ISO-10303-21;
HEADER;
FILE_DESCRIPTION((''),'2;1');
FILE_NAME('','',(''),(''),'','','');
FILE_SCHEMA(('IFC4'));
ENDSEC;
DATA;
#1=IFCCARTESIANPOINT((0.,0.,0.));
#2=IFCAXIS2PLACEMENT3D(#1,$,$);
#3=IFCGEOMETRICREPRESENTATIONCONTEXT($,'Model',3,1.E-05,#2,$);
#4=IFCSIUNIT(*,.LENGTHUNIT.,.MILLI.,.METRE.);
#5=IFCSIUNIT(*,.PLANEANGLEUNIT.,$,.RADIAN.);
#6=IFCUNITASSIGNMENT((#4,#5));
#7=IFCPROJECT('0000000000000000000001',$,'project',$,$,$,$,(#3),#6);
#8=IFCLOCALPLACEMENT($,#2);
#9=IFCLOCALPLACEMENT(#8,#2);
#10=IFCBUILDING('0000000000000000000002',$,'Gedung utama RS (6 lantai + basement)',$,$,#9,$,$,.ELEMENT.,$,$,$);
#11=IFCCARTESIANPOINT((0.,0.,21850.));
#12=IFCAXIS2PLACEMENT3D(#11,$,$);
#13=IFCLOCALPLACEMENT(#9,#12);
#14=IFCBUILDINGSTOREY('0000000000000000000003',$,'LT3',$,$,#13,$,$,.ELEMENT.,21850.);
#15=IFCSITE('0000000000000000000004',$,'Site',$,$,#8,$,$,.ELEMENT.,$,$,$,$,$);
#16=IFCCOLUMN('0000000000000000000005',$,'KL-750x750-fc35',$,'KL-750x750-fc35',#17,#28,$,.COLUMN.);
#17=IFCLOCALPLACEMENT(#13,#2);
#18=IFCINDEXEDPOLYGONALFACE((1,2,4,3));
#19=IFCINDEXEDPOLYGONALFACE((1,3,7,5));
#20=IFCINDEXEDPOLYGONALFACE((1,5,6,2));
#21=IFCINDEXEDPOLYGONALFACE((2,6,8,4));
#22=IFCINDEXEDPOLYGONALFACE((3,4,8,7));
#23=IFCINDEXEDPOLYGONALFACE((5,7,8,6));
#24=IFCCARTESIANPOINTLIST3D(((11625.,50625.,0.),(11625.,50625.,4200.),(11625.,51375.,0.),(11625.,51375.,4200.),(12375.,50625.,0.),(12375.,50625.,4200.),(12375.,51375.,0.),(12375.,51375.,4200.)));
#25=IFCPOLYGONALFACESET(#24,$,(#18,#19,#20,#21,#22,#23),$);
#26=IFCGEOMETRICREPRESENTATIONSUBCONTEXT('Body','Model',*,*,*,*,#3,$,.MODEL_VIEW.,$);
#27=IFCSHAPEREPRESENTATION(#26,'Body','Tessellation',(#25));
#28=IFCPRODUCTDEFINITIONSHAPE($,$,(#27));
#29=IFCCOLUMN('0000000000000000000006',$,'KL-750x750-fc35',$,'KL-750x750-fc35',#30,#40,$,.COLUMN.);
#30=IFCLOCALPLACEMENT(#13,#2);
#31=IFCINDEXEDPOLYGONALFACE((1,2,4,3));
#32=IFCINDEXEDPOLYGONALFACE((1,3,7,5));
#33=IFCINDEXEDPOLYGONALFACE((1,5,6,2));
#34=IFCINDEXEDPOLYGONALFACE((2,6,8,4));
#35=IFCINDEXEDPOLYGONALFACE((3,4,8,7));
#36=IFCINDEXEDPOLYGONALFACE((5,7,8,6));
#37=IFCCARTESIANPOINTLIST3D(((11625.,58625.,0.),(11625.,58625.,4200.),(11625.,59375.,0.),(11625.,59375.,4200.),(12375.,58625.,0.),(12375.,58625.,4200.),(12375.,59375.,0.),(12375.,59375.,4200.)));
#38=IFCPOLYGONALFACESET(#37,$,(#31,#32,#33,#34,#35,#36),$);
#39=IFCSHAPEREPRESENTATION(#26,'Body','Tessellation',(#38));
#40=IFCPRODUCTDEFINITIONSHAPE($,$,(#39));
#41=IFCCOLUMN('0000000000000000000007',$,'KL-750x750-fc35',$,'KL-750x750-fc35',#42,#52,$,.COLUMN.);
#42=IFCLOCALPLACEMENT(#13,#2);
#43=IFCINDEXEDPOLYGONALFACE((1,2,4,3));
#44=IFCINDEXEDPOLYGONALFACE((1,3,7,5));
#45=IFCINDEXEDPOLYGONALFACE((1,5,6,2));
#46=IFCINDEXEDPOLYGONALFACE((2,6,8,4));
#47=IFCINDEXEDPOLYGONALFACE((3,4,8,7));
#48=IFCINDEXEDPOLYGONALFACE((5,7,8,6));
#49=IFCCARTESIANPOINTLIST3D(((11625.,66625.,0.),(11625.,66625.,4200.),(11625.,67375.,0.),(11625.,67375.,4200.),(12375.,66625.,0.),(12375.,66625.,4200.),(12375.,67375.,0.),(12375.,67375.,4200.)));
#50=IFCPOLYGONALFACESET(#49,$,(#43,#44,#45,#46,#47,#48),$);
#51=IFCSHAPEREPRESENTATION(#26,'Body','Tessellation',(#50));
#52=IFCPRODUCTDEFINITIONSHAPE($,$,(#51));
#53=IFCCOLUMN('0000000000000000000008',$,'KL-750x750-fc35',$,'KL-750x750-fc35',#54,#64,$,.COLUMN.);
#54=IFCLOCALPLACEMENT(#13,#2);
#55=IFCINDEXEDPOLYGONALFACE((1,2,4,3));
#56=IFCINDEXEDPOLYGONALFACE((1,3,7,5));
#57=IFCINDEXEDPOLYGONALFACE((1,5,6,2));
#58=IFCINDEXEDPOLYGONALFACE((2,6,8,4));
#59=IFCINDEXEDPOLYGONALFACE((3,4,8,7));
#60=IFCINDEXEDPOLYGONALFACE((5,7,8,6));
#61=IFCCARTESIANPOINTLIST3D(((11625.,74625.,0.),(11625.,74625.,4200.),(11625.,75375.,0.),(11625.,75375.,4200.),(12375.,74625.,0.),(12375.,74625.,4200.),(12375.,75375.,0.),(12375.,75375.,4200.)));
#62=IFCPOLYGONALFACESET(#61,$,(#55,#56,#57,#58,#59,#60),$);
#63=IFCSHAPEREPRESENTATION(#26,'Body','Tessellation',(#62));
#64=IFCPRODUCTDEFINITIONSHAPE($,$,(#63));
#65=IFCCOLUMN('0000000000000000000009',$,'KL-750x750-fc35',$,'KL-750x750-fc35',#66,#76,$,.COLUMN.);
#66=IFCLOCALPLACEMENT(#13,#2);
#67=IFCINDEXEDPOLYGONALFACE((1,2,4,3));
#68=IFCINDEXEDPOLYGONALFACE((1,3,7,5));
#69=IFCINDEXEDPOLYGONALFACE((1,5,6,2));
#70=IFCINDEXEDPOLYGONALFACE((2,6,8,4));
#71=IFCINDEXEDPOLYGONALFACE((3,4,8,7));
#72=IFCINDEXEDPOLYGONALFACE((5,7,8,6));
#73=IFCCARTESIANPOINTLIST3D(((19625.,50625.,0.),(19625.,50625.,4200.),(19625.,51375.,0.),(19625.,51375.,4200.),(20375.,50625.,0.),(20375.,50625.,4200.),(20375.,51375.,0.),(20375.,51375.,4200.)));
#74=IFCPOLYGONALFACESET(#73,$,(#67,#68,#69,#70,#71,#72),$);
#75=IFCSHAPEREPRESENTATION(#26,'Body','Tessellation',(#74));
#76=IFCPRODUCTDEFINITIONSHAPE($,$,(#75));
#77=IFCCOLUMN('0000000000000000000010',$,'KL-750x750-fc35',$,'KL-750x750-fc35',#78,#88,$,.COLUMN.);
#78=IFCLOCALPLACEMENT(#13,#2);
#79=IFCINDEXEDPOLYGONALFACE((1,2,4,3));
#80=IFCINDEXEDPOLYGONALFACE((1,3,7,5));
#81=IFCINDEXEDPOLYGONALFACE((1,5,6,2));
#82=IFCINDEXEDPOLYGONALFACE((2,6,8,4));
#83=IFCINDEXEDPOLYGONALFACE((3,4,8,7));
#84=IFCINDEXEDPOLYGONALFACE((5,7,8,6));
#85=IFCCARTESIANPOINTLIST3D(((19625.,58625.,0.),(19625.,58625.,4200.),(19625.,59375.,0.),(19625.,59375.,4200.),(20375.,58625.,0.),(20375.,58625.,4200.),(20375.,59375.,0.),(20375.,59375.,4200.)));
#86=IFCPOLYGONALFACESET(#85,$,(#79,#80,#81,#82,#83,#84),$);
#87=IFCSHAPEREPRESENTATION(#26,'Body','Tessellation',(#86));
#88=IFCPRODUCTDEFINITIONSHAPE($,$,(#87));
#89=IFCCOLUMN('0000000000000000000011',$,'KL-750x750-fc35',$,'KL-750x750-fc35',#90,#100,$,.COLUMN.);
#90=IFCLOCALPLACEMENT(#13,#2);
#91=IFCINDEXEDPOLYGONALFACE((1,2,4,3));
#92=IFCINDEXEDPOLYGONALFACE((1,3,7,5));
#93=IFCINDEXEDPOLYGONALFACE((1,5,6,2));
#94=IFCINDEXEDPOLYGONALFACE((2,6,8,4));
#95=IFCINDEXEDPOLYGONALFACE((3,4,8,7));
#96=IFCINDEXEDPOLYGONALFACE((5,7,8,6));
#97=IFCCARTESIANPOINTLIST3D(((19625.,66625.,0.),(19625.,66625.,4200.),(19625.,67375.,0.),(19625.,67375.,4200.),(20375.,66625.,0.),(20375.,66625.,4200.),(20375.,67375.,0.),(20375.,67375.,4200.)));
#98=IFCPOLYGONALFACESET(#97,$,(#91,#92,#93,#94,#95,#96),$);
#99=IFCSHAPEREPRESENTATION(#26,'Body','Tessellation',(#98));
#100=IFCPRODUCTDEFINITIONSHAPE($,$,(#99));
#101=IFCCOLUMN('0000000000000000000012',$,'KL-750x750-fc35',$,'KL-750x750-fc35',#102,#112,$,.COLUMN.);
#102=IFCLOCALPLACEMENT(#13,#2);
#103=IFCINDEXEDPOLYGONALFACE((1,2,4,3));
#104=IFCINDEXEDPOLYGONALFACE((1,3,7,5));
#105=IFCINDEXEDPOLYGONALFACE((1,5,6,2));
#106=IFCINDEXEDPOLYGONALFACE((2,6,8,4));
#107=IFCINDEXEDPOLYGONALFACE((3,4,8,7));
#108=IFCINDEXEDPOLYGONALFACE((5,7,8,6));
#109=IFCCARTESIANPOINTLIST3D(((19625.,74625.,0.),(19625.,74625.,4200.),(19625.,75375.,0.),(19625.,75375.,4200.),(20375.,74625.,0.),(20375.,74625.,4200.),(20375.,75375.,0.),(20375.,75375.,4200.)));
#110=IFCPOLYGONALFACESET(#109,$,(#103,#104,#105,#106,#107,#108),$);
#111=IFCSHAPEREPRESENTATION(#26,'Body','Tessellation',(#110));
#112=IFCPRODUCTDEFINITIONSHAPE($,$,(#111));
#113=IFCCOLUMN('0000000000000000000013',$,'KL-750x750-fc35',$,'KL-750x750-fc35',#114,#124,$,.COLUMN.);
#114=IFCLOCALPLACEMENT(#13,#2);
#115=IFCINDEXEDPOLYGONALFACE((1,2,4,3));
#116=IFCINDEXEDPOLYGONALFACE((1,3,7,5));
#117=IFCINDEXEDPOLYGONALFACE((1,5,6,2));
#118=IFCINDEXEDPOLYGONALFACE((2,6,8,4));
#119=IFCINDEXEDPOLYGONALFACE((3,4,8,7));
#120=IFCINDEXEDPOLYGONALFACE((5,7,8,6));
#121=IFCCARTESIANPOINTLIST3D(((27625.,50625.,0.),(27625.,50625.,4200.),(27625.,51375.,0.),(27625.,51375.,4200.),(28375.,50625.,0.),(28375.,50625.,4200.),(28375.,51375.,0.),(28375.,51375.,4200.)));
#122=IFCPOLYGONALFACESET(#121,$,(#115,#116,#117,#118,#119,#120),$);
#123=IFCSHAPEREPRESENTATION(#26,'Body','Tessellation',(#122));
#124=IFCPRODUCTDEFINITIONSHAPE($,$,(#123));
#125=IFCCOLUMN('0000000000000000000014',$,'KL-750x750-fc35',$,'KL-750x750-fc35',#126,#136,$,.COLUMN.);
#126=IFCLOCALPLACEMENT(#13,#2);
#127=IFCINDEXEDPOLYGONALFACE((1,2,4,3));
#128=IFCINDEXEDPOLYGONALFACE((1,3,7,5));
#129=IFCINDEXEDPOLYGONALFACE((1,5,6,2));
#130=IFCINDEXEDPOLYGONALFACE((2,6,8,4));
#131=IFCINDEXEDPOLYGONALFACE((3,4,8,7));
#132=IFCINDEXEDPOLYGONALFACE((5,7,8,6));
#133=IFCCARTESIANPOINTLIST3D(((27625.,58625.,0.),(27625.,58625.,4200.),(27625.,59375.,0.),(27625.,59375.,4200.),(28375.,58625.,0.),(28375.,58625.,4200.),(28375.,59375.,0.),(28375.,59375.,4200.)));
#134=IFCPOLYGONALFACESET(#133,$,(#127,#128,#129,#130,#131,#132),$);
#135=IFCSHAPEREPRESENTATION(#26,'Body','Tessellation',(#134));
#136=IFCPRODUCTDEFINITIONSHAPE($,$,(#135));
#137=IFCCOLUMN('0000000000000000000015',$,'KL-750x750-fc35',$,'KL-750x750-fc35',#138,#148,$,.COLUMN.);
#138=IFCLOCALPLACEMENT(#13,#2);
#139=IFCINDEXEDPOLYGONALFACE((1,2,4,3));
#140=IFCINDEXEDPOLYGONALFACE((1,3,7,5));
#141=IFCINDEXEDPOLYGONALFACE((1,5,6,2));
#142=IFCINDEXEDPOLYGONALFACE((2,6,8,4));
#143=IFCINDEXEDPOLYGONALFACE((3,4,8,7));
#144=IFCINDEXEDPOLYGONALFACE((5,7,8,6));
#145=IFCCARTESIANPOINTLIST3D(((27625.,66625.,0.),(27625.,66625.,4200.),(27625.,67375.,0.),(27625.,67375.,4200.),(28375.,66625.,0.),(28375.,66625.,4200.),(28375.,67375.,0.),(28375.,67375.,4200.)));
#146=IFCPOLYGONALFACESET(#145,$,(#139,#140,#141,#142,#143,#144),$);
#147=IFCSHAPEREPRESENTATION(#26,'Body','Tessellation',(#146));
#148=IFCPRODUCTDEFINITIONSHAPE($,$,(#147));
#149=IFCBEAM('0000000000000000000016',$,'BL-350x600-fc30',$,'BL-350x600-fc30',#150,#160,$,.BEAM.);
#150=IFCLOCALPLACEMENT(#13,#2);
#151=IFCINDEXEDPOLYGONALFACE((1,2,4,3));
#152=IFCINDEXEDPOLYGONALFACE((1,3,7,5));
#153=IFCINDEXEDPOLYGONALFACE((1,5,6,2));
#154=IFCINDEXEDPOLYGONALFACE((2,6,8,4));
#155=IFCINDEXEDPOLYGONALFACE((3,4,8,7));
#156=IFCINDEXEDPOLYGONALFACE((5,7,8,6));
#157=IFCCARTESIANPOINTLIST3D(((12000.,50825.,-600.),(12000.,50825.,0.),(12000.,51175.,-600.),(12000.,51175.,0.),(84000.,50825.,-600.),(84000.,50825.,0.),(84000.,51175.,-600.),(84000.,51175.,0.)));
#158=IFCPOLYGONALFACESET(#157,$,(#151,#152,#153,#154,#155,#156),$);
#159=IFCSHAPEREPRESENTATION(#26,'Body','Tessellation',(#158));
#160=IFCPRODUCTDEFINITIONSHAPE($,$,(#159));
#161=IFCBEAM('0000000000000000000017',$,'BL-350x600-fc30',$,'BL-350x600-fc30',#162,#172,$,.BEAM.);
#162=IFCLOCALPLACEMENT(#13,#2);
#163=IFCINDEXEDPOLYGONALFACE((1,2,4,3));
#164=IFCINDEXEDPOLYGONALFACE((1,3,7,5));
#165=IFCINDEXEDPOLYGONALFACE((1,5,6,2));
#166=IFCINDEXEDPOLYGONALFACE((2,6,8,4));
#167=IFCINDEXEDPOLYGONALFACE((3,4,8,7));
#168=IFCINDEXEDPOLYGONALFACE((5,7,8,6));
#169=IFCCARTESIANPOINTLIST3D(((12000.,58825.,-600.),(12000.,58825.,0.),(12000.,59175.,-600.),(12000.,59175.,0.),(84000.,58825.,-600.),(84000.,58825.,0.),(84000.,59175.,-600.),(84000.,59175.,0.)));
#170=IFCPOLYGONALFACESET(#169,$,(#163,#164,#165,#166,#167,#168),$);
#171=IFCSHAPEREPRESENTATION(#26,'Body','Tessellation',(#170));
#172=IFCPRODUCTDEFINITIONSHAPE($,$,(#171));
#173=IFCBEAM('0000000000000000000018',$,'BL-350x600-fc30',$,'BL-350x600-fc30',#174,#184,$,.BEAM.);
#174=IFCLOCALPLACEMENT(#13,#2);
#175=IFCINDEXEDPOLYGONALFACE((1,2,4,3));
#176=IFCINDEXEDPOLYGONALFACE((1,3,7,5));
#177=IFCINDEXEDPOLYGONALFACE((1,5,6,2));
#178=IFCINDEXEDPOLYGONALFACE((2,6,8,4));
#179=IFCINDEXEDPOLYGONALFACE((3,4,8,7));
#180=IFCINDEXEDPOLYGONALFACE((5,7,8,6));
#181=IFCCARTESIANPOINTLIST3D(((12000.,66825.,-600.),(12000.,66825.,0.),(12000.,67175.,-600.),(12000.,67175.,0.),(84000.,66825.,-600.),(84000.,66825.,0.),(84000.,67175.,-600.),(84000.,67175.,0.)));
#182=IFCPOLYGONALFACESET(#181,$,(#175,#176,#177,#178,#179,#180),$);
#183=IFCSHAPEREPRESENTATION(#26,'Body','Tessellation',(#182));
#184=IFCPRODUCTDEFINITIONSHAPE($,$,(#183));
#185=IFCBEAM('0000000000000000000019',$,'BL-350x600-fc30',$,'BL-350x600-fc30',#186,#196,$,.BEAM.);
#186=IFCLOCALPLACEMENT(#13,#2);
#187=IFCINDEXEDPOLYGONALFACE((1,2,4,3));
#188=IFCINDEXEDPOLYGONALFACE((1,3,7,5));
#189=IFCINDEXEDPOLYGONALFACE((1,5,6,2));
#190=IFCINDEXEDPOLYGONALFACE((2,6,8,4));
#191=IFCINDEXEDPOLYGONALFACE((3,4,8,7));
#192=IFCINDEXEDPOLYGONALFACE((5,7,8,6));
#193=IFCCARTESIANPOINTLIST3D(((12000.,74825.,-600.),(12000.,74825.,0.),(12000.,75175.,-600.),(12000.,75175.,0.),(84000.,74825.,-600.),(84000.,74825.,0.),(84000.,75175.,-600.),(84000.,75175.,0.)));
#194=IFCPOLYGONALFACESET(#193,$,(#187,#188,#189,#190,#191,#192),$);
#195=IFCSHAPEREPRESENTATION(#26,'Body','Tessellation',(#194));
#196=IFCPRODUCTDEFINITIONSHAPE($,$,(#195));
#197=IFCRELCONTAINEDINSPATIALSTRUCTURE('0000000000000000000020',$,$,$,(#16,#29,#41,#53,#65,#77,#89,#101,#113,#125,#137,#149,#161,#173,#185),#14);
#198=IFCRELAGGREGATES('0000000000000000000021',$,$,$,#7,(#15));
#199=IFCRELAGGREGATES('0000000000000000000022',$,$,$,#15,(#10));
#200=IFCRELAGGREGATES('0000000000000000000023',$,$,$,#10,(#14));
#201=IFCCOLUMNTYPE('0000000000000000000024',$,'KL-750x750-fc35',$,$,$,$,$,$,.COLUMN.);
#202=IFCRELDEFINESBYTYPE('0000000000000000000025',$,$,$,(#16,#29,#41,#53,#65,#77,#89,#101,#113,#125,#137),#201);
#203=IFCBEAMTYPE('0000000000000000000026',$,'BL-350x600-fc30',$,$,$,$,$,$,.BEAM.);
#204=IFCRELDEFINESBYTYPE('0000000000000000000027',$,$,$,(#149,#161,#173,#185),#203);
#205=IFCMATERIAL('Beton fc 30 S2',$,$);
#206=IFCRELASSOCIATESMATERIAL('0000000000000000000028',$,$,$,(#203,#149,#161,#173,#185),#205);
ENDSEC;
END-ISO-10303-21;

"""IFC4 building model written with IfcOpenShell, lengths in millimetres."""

from ifc_helpers import new_model, si_unit, frame, origin, origin_2d, place, context, subcontext, project, spatial, rectangle, extrude, material, material_profile, profile_set, profile_usage, type_object, element, save


model = new_model("IFC4")

# Units and contexts
model_context = context("Model", 3, precision=1e-05, world=origin())
body_context = subcontext(model_context, "Body", "Model", "MODEL_VIEW")
ifc_project = project(units=[si_unit("LENGTHUNIT", "METRE", prefix="MILLI"), si_unit("PLANEANGLEUNIT", "RADIAN")], contexts=[model_context])

# Site, building, storey
site_placement = place(None, origin())
site = spatial("IfcSite", under=ifc_project, at=site_placement, Name="Site", CompositionType="ELEMENT")
building_placement = place(site_placement, origin())
building = spatial("IfcBuilding", under=site, at=building_placement, Name="Gedung utama RS (6 lantai + basement)", CompositionType="ELEMENT")
storey_placement = place(building_placement, frame((0.0, 0.0, 21850.0)))
storey = spatial("IfcBuildingStorey", under=building, at=storey_placement, Name="LT3", CompositionType="ELEMENT", Elevation=21850.0)

# Columns
ifc_material_profile_1 = material_profile(None, rectangle(XDim=750.0, YDim=750.0, at=origin_2d()), Name="KL-750x750-fc35")
ifc_profile_set_1 = profile_set([ifc_material_profile_1], Name="KL-750x750-fc35")
ifc_profile_usage_1 = profile_usage(ifc_profile_set_1, cardinal=5)
column_type = type_object("IfcColumnType", Name="KL-750x750-fc35", PredefinedType="COLUMN", material=ifc_profile_set_1)
for number, where, z_axis, x_axis, name in (
    (1, (12000.0, 51000.0, 0.0), (0.0, 0.0, 1.0), (1.0, 0.0, 0.0), "KL-750x750-fc35"),
    (2, (12000.0, 59000.0, 0.0), (0.0, 0.0, 1.0), (1.0, 0.0, 0.0), "KL-750x750-fc35"),
    (3, (12000.0, 67000.0, 0.0), (0.0, 0.0, 1.0), (1.0, 0.0, 0.0), "KL-750x750-fc35"),
    (4, (12000.0, 75000.0, 0.0), (0.0, 0.0, 1.0), (1.0, 0.0, 0.0), "KL-750x750-fc35"),
    (5, (20000.0, 51000.0, 0.0), (0.0, 0.0, 1.0), (1.0, 0.0, 0.0), "KL-750x750-fc35"),
    (6, (20000.0, 59000.0, 0.0), (0.0, 0.0, 1.0), (1.0, 0.0, 0.0), "KL-750x750-fc35"),
    (7, (20000.0, 67000.0, 0.0), (0.0, 0.0, 1.0), (1.0, 0.0, 0.0), "KL-750x750-fc35"),
    (8, (20000.0, 75000.0, 0.0), (0.0, 0.0, 1.0), (1.0, 0.0, 0.0), "KL-750x750-fc35"),
    (9, (28000.0, 51000.0, 0.0), (0.0, 0.0, 1.0), (1.0, 0.0, 0.0), "KL-750x750-fc35"),
    (10, (28000.0, 59000.0, 0.0), (0.0, 0.0, 1.0), (1.0, 0.0, 0.0), "KL-750x750-fc35"),
    (11, (28000.0, 67000.0, 0.0), (0.0, 0.0, 1.0), (1.0, 0.0, 0.0), "KL-750x750-fc35"),
):
    element("IfcColumn", number, at=place(storey_placement, frame(where, z_axis=z_axis, x_axis=x_axis)), inside=storey, type_object=column_type, material=ifc_profile_usage_1, Name=name, ObjectType="KL-750x750-fc35", PredefinedType="COLUMN", context=body_context, shape_type="SweptSolid", body=[
        extrude(rectangle(XDim=750.0, YDim=750.0, at=origin_2d()), origin(), (0.0, 0.0, 1.0), 4200.0),
    ])

# Beams
ifc_material_1 = material(Name="Beton fc 30 S2")
ifc_material_profile_2 = material_profile(ifc_material_1, rectangle(XDim=350.0, YDim=600.0, at=origin_2d()), Name="BL-350x600-fc30")
ifc_profile_set_2 = profile_set([ifc_material_profile_2], Name="BL-350x600-fc30")
ifc_profile_usage_2 = profile_usage(ifc_profile_set_2, cardinal=8)
beam_type = type_object("IfcBeamType", Name="BL-350x600-fc30", PredefinedType="BEAM", material=ifc_profile_set_2)
for number, where, name in (
    (12, (12000.0, 51000.0, -300.0), "BL-350x600-fc30"),
    (13, (12000.0, 59000.0, -300.0), "BL-350x600-fc30"),
    (14, (12000.0, 67000.0, -300.0), "BL-350x600-fc30"),
    (15, (12000.0, 75000.0, -300.0), "BL-350x600-fc30"),
):
    element("IfcBeam", number, at=place(storey_placement, frame(where)), inside=storey, type_object=beam_type, material=ifc_profile_usage_2, Name=name, ObjectType="BL-350x600-fc30", PredefinedType="BEAM", context=body_context, shape_type="SweptSolid", body=[
        extrude(rectangle(XDim=350.0, YDim=600.0, at=origin_2d()), frame((0.0, 0.0, 0.0), z_axis=(1.0, 0.0, 0.0), x_axis=(0.0, 1.0, 0.0)), (0.0, 0.0, 1.0), 72000.0),
    ])

save(model, "model.ifc")
